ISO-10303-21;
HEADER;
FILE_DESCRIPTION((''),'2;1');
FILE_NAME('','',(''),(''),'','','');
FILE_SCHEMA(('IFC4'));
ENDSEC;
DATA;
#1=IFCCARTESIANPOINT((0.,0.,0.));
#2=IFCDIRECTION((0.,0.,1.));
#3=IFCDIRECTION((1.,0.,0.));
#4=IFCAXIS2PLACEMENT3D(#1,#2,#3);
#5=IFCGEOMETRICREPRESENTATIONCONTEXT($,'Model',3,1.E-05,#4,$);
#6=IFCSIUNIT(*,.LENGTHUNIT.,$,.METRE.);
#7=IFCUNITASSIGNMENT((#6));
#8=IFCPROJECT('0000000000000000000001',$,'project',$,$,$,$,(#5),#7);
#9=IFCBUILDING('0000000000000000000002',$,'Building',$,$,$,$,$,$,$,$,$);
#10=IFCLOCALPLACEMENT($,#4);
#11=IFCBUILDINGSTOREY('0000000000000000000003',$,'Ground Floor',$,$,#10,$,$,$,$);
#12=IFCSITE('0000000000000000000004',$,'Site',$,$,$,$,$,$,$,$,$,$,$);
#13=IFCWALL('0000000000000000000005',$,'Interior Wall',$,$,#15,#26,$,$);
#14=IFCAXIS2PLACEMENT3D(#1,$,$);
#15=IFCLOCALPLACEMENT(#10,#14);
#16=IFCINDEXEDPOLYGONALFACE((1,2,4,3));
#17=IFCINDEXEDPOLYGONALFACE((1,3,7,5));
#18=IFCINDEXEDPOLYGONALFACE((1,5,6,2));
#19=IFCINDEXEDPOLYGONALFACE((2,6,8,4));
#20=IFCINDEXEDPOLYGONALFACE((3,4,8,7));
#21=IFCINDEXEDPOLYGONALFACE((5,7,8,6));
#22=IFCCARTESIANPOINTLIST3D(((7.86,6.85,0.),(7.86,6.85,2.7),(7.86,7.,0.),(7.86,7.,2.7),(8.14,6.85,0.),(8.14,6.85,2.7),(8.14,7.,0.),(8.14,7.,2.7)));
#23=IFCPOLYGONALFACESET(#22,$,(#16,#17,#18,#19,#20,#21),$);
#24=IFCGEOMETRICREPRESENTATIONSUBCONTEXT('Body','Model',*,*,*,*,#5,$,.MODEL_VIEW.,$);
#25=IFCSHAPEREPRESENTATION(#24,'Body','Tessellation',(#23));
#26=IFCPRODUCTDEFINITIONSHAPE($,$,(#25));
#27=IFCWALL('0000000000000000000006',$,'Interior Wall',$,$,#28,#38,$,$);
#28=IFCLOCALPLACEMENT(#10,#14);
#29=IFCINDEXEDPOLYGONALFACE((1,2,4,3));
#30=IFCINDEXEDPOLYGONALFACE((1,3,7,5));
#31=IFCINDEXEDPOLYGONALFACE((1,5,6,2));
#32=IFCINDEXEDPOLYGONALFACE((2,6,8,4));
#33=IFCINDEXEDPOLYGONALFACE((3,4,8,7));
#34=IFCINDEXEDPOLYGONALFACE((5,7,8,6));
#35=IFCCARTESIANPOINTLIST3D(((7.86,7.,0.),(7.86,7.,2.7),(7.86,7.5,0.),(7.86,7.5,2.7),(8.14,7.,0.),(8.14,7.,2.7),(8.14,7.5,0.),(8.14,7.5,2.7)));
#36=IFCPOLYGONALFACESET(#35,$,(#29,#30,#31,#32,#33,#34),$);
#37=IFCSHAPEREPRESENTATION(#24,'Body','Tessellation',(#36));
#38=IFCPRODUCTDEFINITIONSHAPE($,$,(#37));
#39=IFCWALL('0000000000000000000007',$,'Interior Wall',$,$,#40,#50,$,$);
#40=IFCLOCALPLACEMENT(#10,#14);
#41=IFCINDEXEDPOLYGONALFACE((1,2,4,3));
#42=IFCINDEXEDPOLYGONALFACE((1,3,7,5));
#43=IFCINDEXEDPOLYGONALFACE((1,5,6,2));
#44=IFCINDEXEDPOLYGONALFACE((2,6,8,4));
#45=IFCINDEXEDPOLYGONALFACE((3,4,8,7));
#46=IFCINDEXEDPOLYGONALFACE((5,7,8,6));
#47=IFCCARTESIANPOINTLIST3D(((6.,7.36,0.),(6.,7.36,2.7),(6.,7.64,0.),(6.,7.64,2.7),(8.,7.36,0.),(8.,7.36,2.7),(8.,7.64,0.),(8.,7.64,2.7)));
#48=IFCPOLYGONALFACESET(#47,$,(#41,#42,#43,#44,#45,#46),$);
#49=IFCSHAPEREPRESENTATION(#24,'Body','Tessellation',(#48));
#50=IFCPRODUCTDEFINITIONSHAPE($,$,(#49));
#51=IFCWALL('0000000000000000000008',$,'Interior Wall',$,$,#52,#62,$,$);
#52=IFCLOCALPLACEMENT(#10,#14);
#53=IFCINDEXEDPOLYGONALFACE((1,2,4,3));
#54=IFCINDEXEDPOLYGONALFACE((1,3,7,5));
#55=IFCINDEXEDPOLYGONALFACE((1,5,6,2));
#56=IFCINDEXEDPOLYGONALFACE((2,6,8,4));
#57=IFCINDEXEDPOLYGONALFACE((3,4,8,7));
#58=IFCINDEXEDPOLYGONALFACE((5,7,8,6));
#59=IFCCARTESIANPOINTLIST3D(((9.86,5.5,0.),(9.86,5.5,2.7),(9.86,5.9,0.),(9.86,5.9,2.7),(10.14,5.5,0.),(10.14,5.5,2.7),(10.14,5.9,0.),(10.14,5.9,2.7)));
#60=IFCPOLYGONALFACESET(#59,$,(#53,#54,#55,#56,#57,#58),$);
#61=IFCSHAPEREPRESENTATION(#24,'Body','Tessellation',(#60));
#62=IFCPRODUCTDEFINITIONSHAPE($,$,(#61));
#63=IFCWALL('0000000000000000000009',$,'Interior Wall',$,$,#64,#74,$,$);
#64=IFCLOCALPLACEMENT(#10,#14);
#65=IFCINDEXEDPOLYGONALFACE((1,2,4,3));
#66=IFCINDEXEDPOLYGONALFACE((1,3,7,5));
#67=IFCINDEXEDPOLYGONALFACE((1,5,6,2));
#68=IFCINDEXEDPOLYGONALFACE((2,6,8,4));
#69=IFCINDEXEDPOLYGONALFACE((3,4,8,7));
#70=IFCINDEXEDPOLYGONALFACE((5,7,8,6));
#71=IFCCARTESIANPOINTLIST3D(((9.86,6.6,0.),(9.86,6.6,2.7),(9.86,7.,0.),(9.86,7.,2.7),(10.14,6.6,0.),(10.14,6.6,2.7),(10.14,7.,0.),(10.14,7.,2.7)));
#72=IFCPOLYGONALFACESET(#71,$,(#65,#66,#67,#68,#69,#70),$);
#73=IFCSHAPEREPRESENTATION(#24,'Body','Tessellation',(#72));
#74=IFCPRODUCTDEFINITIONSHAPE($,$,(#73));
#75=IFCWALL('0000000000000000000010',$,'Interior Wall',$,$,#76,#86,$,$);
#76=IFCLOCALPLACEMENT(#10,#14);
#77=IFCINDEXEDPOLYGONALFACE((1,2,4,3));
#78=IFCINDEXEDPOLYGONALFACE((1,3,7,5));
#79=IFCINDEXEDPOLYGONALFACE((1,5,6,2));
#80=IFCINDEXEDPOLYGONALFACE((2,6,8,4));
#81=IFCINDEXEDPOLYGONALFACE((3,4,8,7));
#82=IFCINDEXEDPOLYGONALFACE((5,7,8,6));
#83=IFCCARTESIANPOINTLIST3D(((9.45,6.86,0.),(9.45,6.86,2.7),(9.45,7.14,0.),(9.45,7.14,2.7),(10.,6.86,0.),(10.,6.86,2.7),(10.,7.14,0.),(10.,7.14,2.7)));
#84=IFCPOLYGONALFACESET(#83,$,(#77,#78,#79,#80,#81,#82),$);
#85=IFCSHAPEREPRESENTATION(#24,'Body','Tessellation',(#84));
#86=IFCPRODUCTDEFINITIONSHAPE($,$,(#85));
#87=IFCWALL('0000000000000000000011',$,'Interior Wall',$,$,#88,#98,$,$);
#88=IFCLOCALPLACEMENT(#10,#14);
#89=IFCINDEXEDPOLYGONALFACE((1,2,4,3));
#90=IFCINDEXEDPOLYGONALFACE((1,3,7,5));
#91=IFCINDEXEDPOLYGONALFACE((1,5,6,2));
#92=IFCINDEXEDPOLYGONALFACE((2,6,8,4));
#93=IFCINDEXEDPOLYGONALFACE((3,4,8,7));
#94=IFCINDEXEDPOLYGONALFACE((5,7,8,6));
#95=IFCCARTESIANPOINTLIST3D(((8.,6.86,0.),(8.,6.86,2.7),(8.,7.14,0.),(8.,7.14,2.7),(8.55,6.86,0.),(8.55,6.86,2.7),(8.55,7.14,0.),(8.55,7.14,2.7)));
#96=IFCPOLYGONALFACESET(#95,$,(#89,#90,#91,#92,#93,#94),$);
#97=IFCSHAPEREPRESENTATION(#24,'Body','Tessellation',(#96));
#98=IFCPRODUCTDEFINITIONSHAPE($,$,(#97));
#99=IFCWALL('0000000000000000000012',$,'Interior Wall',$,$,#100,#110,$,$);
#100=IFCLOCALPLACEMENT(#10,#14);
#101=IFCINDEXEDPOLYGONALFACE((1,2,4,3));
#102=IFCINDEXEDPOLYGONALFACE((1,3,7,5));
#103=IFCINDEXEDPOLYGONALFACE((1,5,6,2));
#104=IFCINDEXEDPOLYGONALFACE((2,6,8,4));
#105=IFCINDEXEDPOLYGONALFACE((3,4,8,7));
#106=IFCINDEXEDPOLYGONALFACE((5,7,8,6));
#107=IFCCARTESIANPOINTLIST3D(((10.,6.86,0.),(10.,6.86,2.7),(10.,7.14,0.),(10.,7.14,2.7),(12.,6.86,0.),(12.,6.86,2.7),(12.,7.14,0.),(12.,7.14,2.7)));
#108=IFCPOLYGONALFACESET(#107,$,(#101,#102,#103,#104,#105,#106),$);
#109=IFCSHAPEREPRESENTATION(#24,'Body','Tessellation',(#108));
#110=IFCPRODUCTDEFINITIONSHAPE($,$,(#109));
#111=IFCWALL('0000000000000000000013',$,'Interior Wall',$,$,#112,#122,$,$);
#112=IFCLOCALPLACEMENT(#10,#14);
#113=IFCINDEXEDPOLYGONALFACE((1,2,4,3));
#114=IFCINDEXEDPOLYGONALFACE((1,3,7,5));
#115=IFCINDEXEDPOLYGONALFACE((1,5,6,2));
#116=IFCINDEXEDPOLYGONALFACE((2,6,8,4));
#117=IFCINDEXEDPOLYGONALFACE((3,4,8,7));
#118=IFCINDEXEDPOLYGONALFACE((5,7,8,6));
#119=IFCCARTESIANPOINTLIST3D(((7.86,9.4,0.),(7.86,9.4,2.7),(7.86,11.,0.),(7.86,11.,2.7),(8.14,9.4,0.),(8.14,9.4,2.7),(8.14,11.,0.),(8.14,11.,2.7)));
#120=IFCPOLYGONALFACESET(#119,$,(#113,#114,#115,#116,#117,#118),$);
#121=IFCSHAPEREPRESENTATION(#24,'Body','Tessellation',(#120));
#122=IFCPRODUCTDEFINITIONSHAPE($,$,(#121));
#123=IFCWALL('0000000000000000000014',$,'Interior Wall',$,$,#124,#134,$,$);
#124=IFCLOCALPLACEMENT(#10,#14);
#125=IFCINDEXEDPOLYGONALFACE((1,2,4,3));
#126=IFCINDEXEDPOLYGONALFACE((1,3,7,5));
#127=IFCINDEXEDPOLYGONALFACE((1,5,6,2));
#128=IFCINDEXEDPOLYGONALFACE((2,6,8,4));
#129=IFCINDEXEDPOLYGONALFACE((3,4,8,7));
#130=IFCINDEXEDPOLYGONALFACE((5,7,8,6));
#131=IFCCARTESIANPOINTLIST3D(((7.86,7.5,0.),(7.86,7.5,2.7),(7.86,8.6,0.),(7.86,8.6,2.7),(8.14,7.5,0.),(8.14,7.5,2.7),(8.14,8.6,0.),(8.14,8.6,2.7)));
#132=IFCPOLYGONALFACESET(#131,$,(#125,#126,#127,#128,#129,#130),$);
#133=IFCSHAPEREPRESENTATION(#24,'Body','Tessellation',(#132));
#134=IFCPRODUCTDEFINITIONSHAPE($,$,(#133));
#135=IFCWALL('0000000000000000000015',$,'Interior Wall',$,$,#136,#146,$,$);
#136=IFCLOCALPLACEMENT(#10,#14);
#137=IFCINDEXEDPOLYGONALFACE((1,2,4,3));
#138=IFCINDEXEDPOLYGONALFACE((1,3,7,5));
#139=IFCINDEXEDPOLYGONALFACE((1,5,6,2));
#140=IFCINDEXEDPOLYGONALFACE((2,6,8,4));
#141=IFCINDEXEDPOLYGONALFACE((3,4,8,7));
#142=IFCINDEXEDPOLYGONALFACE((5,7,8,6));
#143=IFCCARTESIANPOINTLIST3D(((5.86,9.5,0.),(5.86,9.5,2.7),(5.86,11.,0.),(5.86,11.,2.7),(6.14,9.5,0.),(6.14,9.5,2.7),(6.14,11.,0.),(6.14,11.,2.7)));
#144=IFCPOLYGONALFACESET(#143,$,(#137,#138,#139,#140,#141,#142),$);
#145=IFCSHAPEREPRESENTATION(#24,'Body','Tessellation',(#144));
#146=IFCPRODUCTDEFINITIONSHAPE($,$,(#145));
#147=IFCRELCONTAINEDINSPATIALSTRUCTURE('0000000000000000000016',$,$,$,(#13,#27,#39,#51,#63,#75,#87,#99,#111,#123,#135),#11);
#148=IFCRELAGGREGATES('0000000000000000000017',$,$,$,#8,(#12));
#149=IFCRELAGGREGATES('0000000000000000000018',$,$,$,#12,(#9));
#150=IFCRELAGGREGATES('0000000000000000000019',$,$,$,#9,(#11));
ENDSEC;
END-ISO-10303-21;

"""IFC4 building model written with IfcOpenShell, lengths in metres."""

from ifc_helpers import new_model, si_unit, frame, origin_with_axes, place, context, subcontext, project, spatial, indexed_curve, outline, extrude, element, save


model = new_model("IFC4")

# Units and contexts
model_context = context("Model", 3, precision=1e-05, world=origin_with_axes())
body_context = subcontext(model_context, "Body", "Model", "MODEL_VIEW")
ifc_project = project(units=[si_unit("LENGTHUNIT", "METRE")], contexts=[model_context])

# Site, building, storey
site = spatial("IfcSite", under=ifc_project, Name="Site")
building = spatial("IfcBuilding", under=site, Name="Building")
storey_placement = place(None, origin_with_axes())
storey = spatial("IfcBuildingStorey", under=building, at=storey_placement, Name="Ground Floor")

# Walls
wall_1_placement = place(storey_placement, frame((8.0, 6.85, 0.0), z_axis=(0.0, 0.0, 1.0), x_axis=(0.0, 1.0, 0.0)))
element("IfcWall", 1, at=wall_1_placement, inside=storey, Name="Interior Wall", context=body_context, shape_type="SweptSolid", body=[
    extrude(outline(indexed_curve([(0.0, 0.0), (0.0, 0.28), (0.15, 0.28), (0.15, 0.0), (0.0, 0.0)], self_intersect=False)), frame((0.0, -0.14, 0.0), z_axis=(0.0, 0.0, 1.0), x_axis=(1.0, 0.0, 0.0)), (0.0, 0.0, 1.0), 2.7),
])
wall_2_placement = place(storey_placement, frame((8.0, 7.0, 0.0), z_axis=(0.0, 0.0, 1.0), x_axis=(0.0, 1.0, 0.0)))
element("IfcWall", 2, at=wall_2_placement, inside=storey, Name="Interior Wall", context=body_context, shape_type="SweptSolid", body=[
    extrude(outline(indexed_curve([(0.0, 0.0), (0.0, 0.28), (0.5, 0.28), (0.5, 0.0), (0.0, 0.0)], self_intersect=False)), frame((0.0, -0.14, 0.0), z_axis=(0.0, 0.0, 1.0), x_axis=(1.0, 0.0, 0.0)), (0.0, 0.0, 1.0), 2.7),
])
wall_3_placement = place(storey_placement, frame((8.0, 7.5, 0.0), z_axis=(0.0, 0.0, 1.0), x_axis=(-1.0, 0.0, 0.0)))
element("IfcWall", 3, at=wall_3_placement, inside=storey, Name="Interior Wall", context=body_context, shape_type="SweptSolid", body=[
    extrude(outline(indexed_curve([(0.0, 0.0), (0.0, 0.28), (2.0, 0.28), (2.0, 0.0), (0.0, 0.0)], self_intersect=False)), frame((0.0, -0.14, 0.0), z_axis=(0.0, 0.0, 1.0), x_axis=(1.0, 0.0, 0.0)), (0.0, 0.0, 1.0), 2.7),
])
for number, where, z_axis, x_axis, name in (
    (4, (10.0, 5.5, 0.0), (0.0, 0.0, 1.0), (0.0, 1.0, 0.0), "Interior Wall"),
    (5, (10.0, 6.6, 0.0), (0.0, 0.0, 1.0), (0.0, 1.0, 0.0), "Interior Wall"),
):
    element("IfcWall", number, at=place(storey_placement, frame(where, z_axis=z_axis, x_axis=x_axis)), inside=storey, Name=name, context=body_context, shape_type="SweptSolid", body=[
        extrude(outline(indexed_curve([(0.0, 0.0), (0.0, 0.28), (0.4, 0.28), (0.4, 0.0), (0.0, 0.0)], self_intersect=False)), frame((0.0, -0.14, 0.0), z_axis=(0.0, 0.0, 1.0), x_axis=(1.0, 0.0, 0.0)), (0.0, 0.0, 1.0), 2.7),
    ])
for number, where, z_axis, x_axis, name in (
    (6, (10.0, 7.0, 0.0), (0.0, 0.0, 1.0), (-1.0, 0.0, 0.0), "Interior Wall"),
    (7, (8.55, 7.0, 0.0), (0.0, 0.0, 1.0), (-1.0, 0.0, 0.0), "Interior Wall"),
):
    element("IfcWall", number, at=place(storey_placement, frame(where, z_axis=z_axis, x_axis=x_axis)), inside=storey, Name=name, context=body_context, shape_type="SweptSolid", body=[
        extrude(outline(indexed_curve([(0.0, 0.0), (0.0, 0.28), (0.55, 0.28), (0.55, 0.0), (0.0, 0.0)], self_intersect=False)), frame((0.0, -0.14, 0.0), z_axis=(0.0, 0.0, 1.0), x_axis=(1.0, 0.0, 0.0)), (0.0, 0.0, 1.0), 2.7),
    ])
wall_4_placement = place(storey_placement, frame((12.0, 7.0, 0.0), z_axis=(0.0, 0.0, 1.0), x_axis=(-1.0, 0.0, 0.0)))
element("IfcWall", 8, at=wall_4_placement, inside=storey, Name="Interior Wall", context=body_context, shape_type="SweptSolid", body=[
    extrude(outline(indexed_curve([(0.0, 0.0), (0.0, 0.28), (2.0, 0.28), (2.0, 0.0), (0.0, 0.0)], self_intersect=False)), frame((0.0, -0.14, 0.0), z_axis=(0.0, 0.0, 1.0), x_axis=(1.0, 0.0, 0.0)), (0.0, 0.0, 1.0), 2.7),
])
wall_5_placement = place(storey_placement, frame((8.0, 11.0, 0.0), z_axis=(0.0, 0.0, 1.0), x_axis=(0.0, -1.0, 0.0)))
element("IfcWall", 9, at=wall_5_placement, inside=storey, Name="Interior Wall", context=body_context, shape_type="SweptSolid", body=[
    extrude(outline(indexed_curve([(0.0, 0.0), (0.0, 0.28), (1.6, 0.28), (1.6, 0.0), (0.0, 0.0)], self_intersect=False)), frame((0.0, -0.14, 0.0), z_axis=(0.0, 0.0, 1.0), x_axis=(1.0, 0.0, 0.0)), (0.0, 0.0, 1.0), 2.7),
])
wall_6_placement = place(storey_placement, frame((8.0, 8.6, 0.0), z_axis=(0.0, 0.0, 1.0), x_axis=(0.0, -1.0, 0.0)))
element("IfcWall", 10, at=wall_6_placement, inside=storey, Name="Interior Wall", context=body_context, shape_type="SweptSolid", body=[
    extrude(outline(indexed_curve([(0.0, 0.0), (0.0, 0.28), (1.1, 0.28), (1.1, 0.0), (0.0, 0.0)], self_intersect=False)), frame((0.0, -0.14, 0.0), z_axis=(0.0, 0.0, 1.0), x_axis=(1.0, 0.0, 0.0)), (0.0, 0.0, 1.0), 2.7),
])
wall_7_placement = place(storey_placement, frame((6.0, 11.0, 0.0), z_axis=(0.0, 0.0, 1.0), x_axis=(0.0, -1.0, 0.0)))
element("IfcWall", 11, at=wall_7_placement, inside=storey, Name="Interior Wall", context=body_context, shape_type="SweptSolid", body=[
    extrude(outline(indexed_curve([(0.0, 0.0), (0.0, 0.28), (1.5, 0.28), (1.5, 0.0), (0.0, 0.0)], self_intersect=False)), frame((0.0, -0.14, 0.0), z_axis=(0.0, 0.0, 1.0), x_axis=(1.0, 0.0, 0.0)), (0.0, 0.0, 1.0), 2.7),
])

save(model, "model.ifc")
